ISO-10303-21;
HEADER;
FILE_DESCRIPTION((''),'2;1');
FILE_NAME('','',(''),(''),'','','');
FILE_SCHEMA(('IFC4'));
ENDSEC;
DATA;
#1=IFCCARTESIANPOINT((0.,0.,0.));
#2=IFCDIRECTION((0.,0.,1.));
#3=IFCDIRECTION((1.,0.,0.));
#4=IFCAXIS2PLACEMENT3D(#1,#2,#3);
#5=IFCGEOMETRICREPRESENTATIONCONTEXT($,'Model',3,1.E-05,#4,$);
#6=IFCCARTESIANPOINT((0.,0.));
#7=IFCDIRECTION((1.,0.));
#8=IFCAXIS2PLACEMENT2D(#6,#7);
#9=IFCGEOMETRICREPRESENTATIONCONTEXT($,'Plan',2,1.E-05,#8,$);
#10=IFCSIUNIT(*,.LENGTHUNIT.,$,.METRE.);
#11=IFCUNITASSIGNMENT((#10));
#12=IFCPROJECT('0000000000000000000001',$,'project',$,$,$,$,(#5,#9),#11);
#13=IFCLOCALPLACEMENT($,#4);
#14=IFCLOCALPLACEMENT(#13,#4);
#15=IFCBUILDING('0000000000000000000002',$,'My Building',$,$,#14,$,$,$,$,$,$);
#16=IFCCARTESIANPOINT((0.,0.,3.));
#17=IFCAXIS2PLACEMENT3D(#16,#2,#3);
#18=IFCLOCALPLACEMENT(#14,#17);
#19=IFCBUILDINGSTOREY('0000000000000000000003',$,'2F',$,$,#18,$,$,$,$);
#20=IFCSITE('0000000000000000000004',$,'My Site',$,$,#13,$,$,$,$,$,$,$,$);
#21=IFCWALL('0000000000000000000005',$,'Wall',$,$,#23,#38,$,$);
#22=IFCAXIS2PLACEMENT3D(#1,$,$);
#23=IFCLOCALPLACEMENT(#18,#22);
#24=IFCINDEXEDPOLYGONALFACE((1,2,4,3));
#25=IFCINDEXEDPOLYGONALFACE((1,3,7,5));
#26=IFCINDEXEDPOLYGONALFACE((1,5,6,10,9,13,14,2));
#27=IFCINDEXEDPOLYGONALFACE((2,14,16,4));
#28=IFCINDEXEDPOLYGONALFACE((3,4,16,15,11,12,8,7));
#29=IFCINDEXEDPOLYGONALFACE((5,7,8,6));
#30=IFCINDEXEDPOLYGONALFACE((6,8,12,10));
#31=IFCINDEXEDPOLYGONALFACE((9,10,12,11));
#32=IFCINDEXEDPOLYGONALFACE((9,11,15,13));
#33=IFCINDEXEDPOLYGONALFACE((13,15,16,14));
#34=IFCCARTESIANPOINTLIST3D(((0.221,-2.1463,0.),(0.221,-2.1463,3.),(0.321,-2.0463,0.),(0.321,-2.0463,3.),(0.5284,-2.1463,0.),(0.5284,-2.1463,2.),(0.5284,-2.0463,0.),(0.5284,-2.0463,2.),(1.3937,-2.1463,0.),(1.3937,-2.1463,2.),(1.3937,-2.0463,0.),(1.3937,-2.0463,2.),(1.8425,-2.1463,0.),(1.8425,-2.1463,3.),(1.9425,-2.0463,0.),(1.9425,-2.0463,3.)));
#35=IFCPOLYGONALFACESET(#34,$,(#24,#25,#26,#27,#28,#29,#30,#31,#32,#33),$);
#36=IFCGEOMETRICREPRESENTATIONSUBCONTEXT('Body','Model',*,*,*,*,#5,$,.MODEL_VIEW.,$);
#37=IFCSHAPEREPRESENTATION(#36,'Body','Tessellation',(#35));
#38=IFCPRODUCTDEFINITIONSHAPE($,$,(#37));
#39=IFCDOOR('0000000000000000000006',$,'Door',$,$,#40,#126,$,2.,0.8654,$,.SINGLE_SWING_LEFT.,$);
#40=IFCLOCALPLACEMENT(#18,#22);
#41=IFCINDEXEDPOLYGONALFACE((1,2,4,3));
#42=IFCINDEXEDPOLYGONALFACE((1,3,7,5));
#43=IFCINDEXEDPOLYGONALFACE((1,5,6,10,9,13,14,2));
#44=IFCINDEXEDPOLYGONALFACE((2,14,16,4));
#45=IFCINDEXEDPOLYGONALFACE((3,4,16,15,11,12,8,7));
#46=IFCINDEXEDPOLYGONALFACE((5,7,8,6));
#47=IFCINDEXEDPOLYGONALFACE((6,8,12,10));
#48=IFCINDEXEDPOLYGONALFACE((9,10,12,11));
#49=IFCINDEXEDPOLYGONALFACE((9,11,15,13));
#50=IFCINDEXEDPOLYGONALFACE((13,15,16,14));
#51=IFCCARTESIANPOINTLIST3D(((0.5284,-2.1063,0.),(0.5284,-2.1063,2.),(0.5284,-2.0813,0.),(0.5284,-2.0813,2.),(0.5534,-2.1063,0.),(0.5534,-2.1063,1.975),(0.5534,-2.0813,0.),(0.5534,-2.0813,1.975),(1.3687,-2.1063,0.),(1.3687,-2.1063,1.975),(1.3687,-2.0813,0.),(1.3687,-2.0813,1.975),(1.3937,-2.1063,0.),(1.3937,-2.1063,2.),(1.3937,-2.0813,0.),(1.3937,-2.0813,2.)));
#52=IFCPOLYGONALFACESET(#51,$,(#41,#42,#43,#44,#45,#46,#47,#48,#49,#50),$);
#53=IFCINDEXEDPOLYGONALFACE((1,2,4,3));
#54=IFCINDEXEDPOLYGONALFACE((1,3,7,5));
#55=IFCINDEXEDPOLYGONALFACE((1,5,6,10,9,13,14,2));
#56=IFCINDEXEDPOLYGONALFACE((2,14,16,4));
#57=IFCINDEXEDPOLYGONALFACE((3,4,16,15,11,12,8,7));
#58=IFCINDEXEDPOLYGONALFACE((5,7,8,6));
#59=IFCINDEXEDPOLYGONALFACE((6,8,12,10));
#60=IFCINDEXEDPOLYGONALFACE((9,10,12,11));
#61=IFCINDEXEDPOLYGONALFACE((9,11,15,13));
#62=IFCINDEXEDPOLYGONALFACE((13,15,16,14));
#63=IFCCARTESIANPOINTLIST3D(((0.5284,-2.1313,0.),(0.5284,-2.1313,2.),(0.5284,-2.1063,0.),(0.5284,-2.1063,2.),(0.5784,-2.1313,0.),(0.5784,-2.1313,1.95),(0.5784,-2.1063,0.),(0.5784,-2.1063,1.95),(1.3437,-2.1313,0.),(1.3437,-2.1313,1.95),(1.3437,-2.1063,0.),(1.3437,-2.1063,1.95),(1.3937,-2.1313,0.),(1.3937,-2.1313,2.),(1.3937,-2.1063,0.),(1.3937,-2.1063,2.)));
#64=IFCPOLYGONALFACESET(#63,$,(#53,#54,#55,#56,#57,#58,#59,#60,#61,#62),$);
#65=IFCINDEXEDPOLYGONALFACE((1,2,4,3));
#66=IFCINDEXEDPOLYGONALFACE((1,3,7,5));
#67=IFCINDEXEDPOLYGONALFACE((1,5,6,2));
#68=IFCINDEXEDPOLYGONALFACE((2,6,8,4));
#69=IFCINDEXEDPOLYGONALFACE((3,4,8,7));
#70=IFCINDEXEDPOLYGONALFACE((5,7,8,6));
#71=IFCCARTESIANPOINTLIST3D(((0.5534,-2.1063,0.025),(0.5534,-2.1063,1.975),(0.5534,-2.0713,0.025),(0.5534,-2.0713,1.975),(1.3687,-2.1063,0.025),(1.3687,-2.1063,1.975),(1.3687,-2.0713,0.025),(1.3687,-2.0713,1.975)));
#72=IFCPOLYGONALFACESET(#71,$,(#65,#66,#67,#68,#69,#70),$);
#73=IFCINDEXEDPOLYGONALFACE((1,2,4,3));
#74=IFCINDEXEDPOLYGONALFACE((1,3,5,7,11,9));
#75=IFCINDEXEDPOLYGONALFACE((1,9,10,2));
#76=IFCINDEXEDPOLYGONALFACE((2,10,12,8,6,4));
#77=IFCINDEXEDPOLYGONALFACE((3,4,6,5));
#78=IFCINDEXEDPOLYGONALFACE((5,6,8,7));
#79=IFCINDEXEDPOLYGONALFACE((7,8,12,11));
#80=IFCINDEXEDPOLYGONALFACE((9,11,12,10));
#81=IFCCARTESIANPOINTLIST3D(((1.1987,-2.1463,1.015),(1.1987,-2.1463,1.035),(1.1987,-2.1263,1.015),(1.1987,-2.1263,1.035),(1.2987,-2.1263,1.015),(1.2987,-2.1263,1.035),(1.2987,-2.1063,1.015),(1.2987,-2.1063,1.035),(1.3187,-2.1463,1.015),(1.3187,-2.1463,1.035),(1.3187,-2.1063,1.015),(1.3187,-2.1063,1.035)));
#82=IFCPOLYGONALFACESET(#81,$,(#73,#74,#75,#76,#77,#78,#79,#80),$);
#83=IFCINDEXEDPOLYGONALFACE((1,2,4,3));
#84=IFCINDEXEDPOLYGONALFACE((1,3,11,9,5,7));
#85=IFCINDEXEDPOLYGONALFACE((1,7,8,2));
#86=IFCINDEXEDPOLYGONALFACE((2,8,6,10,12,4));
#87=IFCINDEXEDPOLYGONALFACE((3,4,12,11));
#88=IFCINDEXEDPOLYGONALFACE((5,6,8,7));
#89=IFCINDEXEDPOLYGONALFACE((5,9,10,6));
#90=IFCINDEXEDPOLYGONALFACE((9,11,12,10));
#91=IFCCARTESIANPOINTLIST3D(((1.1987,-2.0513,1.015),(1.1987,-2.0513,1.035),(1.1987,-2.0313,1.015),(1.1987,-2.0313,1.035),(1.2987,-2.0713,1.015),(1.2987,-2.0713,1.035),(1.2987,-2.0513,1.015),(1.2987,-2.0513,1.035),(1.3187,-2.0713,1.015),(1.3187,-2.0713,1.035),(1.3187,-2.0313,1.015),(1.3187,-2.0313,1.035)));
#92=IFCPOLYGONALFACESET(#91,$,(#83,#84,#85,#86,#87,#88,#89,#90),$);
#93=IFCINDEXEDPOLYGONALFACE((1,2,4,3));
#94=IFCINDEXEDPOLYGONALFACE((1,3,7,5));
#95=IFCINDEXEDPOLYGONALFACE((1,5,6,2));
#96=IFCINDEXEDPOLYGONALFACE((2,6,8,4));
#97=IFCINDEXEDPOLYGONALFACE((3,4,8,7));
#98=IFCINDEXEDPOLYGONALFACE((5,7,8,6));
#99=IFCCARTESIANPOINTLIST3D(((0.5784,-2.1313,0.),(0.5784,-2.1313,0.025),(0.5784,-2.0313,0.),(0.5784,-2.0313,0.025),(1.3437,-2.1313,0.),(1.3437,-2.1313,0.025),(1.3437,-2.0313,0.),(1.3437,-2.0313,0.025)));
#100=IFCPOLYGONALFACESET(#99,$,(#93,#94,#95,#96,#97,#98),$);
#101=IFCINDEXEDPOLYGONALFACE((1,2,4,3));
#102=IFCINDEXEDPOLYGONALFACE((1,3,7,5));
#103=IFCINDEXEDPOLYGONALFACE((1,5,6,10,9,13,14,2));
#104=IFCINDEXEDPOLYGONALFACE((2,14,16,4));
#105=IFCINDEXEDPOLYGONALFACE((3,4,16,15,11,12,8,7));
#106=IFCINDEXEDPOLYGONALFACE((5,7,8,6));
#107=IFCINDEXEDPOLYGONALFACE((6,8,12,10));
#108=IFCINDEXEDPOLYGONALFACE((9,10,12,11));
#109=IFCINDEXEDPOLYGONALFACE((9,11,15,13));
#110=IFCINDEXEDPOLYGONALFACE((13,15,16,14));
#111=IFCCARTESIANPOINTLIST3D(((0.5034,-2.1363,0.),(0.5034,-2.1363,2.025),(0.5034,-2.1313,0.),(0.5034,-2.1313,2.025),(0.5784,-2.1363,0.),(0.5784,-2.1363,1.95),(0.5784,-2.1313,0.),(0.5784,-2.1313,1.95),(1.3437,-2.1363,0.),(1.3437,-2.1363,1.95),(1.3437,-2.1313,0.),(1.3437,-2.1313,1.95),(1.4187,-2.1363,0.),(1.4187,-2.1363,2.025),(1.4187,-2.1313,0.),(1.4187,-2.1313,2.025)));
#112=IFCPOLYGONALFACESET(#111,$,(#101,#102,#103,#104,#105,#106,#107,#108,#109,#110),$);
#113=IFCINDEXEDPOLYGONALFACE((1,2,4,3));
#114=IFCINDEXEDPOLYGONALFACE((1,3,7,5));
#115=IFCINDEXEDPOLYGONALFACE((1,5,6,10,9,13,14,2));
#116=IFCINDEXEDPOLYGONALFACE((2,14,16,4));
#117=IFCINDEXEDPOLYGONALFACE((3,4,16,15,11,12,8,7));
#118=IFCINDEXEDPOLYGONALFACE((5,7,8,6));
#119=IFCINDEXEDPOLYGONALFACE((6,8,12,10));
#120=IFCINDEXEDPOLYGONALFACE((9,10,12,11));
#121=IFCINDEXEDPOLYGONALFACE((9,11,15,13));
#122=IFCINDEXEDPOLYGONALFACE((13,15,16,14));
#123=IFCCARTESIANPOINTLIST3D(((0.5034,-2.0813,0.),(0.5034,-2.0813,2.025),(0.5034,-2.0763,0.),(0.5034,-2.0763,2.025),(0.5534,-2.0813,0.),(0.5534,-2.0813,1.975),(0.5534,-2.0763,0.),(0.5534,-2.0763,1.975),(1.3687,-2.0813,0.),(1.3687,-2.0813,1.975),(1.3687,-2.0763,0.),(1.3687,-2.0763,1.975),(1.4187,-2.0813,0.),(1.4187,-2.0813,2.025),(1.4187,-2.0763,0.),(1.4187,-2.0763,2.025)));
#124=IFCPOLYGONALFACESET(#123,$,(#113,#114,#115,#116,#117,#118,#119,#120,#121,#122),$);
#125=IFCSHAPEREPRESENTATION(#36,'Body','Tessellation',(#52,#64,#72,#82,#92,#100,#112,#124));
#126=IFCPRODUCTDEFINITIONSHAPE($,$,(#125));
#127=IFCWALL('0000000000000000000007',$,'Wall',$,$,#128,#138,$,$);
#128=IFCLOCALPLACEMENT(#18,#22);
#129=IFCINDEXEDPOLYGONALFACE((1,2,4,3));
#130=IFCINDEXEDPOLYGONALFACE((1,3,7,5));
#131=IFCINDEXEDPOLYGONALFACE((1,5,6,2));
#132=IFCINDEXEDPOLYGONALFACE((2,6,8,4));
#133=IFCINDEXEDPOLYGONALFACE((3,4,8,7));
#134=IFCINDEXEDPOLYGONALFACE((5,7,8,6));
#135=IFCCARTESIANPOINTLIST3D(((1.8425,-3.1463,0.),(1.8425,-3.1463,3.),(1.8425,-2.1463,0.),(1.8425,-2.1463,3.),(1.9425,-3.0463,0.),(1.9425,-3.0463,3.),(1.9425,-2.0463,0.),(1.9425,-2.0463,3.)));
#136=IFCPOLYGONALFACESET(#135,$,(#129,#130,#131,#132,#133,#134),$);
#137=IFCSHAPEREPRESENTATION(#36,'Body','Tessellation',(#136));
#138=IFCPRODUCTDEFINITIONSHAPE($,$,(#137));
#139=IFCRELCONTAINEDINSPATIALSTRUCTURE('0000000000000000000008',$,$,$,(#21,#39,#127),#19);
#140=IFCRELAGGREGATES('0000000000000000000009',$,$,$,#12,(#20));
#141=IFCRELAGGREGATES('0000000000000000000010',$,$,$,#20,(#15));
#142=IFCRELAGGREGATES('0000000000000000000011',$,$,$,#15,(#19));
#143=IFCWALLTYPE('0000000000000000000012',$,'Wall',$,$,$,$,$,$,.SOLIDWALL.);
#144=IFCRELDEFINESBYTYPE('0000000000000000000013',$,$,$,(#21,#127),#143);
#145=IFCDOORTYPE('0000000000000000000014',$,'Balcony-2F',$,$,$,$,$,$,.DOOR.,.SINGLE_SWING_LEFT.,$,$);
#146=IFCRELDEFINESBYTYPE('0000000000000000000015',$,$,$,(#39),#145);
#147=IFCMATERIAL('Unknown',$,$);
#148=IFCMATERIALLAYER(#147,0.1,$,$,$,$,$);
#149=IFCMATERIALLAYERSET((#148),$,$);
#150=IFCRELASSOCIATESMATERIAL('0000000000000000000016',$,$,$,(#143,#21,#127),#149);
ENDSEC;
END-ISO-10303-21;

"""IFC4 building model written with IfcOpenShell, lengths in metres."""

from ifc_helpers import new_model, entity, si_unit, frame, origin_with_axes, origin_2d_with_axis, place, context, subcontext, project, spatial, line, indexed_curve, outline, extrude, shape, source, transform, mapped, material, layer, layer_set, layer_usage, type_object, type_shapes, element, fill, save


model = new_model("IFC4")

# Units and contexts
model_context = context("Model", 3, precision=1e-05, world=origin_with_axes())
plan_context = context("Plan", 2, precision=1e-05, world=origin_2d_with_axis())
body_context_1 = subcontext(model_context, "Body", "Model", "MODEL_VIEW")
body_context_2 = subcontext(plan_context, "Body", "Plan", "PLAN_VIEW")
ifc_project = project(units=[si_unit("LENGTHUNIT", "METRE")], contexts=[model_context, plan_context])

# Site, building, storey
site_placement = place(None, origin_with_axes())
site = spatial("IfcSite", under=ifc_project, at=site_placement, Name="My Site")
building_placement = place(site_placement, origin_with_axes())
building = spatial("IfcBuilding", under=site, at=building_placement, Name="My Building")
storey_placement = place(building_placement, frame((0.0, 0.0, 3.0), z_axis=(0.0, 0.0, 1.0), x_axis=(1.0, 0.0, 0.0)))
storey = spatial("IfcBuildingStorey", under=building, at=storey_placement, Name="2F")

# Shared definitions
ifc_material_1 = material(Name="Unknown")

# Shared definitions
ifc_layer_1 = layer(ifc_material_1, 0.1)
ifc_layer_set_1 = layer_set([ifc_layer_1])
wall_type = type_object("IfcWallType", Name="Wall", PredefinedType="SOLIDWALL", material=ifc_layer_set_1)

# Wall, opening, door
ifc_layer_usage_1 = layer_usage(ifc_layer_set_1, "AXIS2", "POSITIVE", 0.0)
wall_1_placement = place(storey_placement, frame((0.221, -2.1463, 0.0), z_axis=(0.0, 0.0, 1.0), x_axis=(1.0, 0.0, 0.0)))
wall_1 = element("IfcWall", 1, at=wall_1_placement, inside=storey, type_object=wall_type, material=ifc_layer_usage_1, Name="Wall", context=body_context_1, shape_type="SweptSolid", body=[
    extrude(outline(indexed_curve([(0.0, 0.0), (0.1, 0.1), (1.7215, 0.1), (1.6215, 0.0)], segments=[line(1, 2, 3, 4, 1)])), origin_with_axes(), (0.0, 0.0, 1.0), 3.0),
])
shared_shape_1 = source(origin_with_axes(), body_context_1, "Body", "SweptSolid", [
    extrude(outline(indexed_curve([(0.0, 0.0), (0.8654, 0.0), (0.8654, 2.0), (0.0, 2.0)], segments=[line(1, 2, 3, 4, 1)])), frame((0.0, -0.6, 0.0), z_axis=(0.0, -1.0, 0.0), x_axis=(1.0, 0.0, 0.0)), (0.0, 0.0, -1.0), 1.2),
])
opening_1_placement = place(wall_1_placement, frame((0.3074, 0.015, 0.0), z_axis=(0.0, 0.0, 1.0), x_axis=(1.0, 0.0, 0.0)))
opening_1 = element("IfcOpeningElement", 2, at=opening_1_placement, cuts=wall_1, PredefinedType="OPENING", context=body_context_1, shape_type="MappedRepresentation", body=[
    mapped(shared_shape_1, transform((0.0, 0.0, 0.0), x_axis=(1.0, 0.0, 0.0), y_axis=(0.0, 1.0, 0.0), z_axis=(0.0, 0.0, 1.0), scale=1.0)),
])
door_type_1 = type_object("IfcDoorType", Name="Balcony-2F", OperationType="SINGLE_SWING_LEFT", PredefinedType="DOOR")
shared_shape_2 = source(origin_with_axes(), body_context_1, "Body", "SweptSolid", [
    extrude(outline(indexed_curve([(0.0, 0.0), (0.0, 2.0), (0.8654, 2.0), (0.8654, 0.0), (0.8404, 0.0), (0.8404, 1.975), (0.025, 1.975), (0.025, 0.0)], segments=[line(1, 2, 3, 4, 5, 6, 7, 8, 1)])), frame((0.0, 0.025, 0.0), z_axis=(0.0, -1.0, 0.0), x_axis=(1.0, 0.0, 0.0)), (0.0, 0.0, -1.0), 0.025),
    extrude(outline(indexed_curve([(0.0, 0.0), (0.0, 2.0), (0.8654, 2.0), (0.8654, 0.0), (0.8154, 0.0), (0.8154, 1.95), (0.05, 1.95), (0.05, 0.0)], segments=[line(1, 2, 3, 4, 5, 6, 7, 8, 1)])), frame((0.0, 0.0, 0.0), z_axis=(0.0, -1.0, 0.0), x_axis=(1.0, 0.0, 0.0)), (0.0, 0.0, -1.0), 0.025),
    extrude(outline(indexed_curve([(0.0, 0.0), (0.8154, 0.0), (0.8154, 0.035), (0.0, 0.035)], segments=[line(1, 2, 3, 4, 1)])), frame((0.025, 0.025, 0.025), z_axis=(0.0, 0.0, 1.0), x_axis=(1.0, 0.0, 0.0)), (0.0, 0.0, 1.0), 1.95),
    extrude(outline(indexed_curve([(0.0, 0.0), (0.0, -0.04), (-0.12, -0.04), (-0.12, -0.02), (-0.02, -0.02), (-0.02, 0.0)], segments=[line(1, 2, 3, 4, 5, 6, 1)])), frame((0.7904, 0.025, 1.015), z_axis=(0.0, 0.0, 1.0), x_axis=(1.0, 0.0, 0.0)), (0.0, 0.0, 1.0), 0.02),
    extrude(outline(indexed_curve([(0.0, 0.0), (0.0, 0.04), (-0.12, 0.04), (-0.12, 0.02), (-0.02, 0.02), (-0.02, 0.0)], segments=[line(1, 2, 3, 4, 5, 6, 1)])), frame((0.7904, 0.06, 1.015), z_axis=(0.0, 0.0, 1.0), x_axis=(1.0, 0.0, 0.0)), (0.0, 0.0, 1.0), 0.02),
    extrude(outline(indexed_curve([(0.0, 0.0), (0.7654, 0.0), (0.7654, 0.1), (0.0, 0.1)], segments=[line(1, 2, 3, 4, 1)])), frame((0.05, 0.0, 0.0), z_axis=(0.0, 0.0, 1.0), x_axis=(1.0, 0.0, 0.0)), (0.0, 0.0, 1.0), 0.025),
    extrude(outline(indexed_curve([(0.0, 0.0), (0.0, 2.025), (0.9154, 2.025), (0.9154, 0.0), (0.8404, 0.0), (0.8404, 1.95), (0.075, 1.95), (0.075, 0.0)], segments=[line(1, 2, 3, 4, 5, 6, 7, 8, 1)])), frame((-0.025, -0.005, 0.0), z_axis=(0.0, -1.0, 0.0), x_axis=(1.0, 0.0, 0.0)), (0.0, 0.0, -1.0), 0.005),
    extrude(outline(indexed_curve([(0.0, 0.0), (0.0, 2.025), (0.9154, 2.025), (0.9154, 0.0), (0.8654, 0.0), (0.8654, 1.975), (0.05, 1.975), (0.05, 0.0)], segments=[line(1, 2, 3, 4, 5, 6, 7, 8, 1)])), frame((-0.025, 0.05, 0.0), z_axis=(0.0, -1.0, 0.0), x_axis=(1.0, 0.0, 0.0)), (0.0, 0.0, -1.0), 0.005),
])
shared_shape_3 = source(origin_with_axes(), body_context_2, "Body", "Curve2D", [
    entity("IfcIndexedPolyCurve", entity("IfcCartesianPointList2D", [[0.0, 0.0], [0.0, 0.05], [0.025, 0.05], [0.025, 0.025], [0.05, 0.025], [0.05, 0.0]]), [entity("IfcLineIndex", [1, 2, 3, 4, 5, 6, 1])]),
    entity("IfcIndexedPolyCurve", entity("IfcCartesianPointList2D", [[0.8654, 0.0], [0.8654, 0.05], [0.8404, 0.05], [0.8404, 0.025], [0.8154, 0.025], [0.8154, 0.0]]), [entity("IfcLineIndex", [1, 2, 3, 4, 5, 6, 1])]),
    entity("IfcTrimmedCurve", entity("IfcEllipse", entity("IfcAxis2Placement2D", entity("IfcCartesianPoint", [0.06, 0.05]), entity("IfcDirection", [1.0, 0.0])), 0.7804, 0.8154), [entity("IfcCartesianPoint", [0.8404, 0.05])], [entity("IfcCartesianPoint", [0.06, 0.8654])], True, "CARTESIAN"),
    entity("IfcIndexedPolyCurve", entity("IfcCartesianPointList2D", [[0.025, 0.05], [0.06, 0.05], [0.06, 0.8654], [0.025, 0.8654]]), [entity("IfcLineIndex", [1, 2, 3, 4, 1])]),
])
type_shapes(door_type_1, [shared_shape_2, shared_shape_3])
door_1_placement = place(opening_1_placement, frame((0.0, 0.0, 0.0), z_axis=(0.0, 0.0, 1.0), x_axis=(1.0, 0.0, 0.0)))
door_1 = element("IfcDoor", 3, at=door_1_placement, inside=storey, type_object=door_type_1, Name="Door", OperationType="SINGLE_SWING_LEFT", OverallHeight=2.0, OverallWidth=0.8654, shapes=[
    shape(body_context_1, "Body", "MappedRepresentation", [mapped(shared_shape_2, transform((0.0, 0.0, 0.0), x_axis=(1.0, 0.0, 0.0), y_axis=(0.0, 1.0, 0.0), z_axis=(0.0, 0.0, 1.0), scale=1.0))]),
    shape(body_context_2, "Body", "MappedRepresentation", [mapped(shared_shape_3, transform((0.0, 0.0, 0.0), x_axis=(1.0, 0.0, 0.0), y_axis=(0.0, 1.0, 0.0), z_axis=(0.0, 0.0, 1.0), scale=1.0))]),
])
fill(opening_1, door_1)

# Wall
ifc_layer_usage_2 = layer_usage(ifc_layer_set_1, "AXIS2", "POSITIVE", 0.0)
wall_2_placement = place(storey_placement, frame((1.8425, -2.1463, 0.0), z_axis=(0.0, 0.0, 1.0), x_axis=(0.0, -1.0, 0.0)))
element("IfcWall", 4, at=wall_2_placement, inside=storey, type_object=wall_type, material=ifc_layer_usage_2, Name="Wall", context=body_context_1, shape_type="SweptSolid", body=[
    extrude(outline(indexed_curve([(0.0, 0.0), (-0.1, 0.1), (0.9, 0.1), (1.0, 0.0)], segments=[line(1, 2, 3, 4, 1)])), origin_with_axes(), (0.0, 0.0, 1.0), 3.0),
])

save(model, "model.ifc")
